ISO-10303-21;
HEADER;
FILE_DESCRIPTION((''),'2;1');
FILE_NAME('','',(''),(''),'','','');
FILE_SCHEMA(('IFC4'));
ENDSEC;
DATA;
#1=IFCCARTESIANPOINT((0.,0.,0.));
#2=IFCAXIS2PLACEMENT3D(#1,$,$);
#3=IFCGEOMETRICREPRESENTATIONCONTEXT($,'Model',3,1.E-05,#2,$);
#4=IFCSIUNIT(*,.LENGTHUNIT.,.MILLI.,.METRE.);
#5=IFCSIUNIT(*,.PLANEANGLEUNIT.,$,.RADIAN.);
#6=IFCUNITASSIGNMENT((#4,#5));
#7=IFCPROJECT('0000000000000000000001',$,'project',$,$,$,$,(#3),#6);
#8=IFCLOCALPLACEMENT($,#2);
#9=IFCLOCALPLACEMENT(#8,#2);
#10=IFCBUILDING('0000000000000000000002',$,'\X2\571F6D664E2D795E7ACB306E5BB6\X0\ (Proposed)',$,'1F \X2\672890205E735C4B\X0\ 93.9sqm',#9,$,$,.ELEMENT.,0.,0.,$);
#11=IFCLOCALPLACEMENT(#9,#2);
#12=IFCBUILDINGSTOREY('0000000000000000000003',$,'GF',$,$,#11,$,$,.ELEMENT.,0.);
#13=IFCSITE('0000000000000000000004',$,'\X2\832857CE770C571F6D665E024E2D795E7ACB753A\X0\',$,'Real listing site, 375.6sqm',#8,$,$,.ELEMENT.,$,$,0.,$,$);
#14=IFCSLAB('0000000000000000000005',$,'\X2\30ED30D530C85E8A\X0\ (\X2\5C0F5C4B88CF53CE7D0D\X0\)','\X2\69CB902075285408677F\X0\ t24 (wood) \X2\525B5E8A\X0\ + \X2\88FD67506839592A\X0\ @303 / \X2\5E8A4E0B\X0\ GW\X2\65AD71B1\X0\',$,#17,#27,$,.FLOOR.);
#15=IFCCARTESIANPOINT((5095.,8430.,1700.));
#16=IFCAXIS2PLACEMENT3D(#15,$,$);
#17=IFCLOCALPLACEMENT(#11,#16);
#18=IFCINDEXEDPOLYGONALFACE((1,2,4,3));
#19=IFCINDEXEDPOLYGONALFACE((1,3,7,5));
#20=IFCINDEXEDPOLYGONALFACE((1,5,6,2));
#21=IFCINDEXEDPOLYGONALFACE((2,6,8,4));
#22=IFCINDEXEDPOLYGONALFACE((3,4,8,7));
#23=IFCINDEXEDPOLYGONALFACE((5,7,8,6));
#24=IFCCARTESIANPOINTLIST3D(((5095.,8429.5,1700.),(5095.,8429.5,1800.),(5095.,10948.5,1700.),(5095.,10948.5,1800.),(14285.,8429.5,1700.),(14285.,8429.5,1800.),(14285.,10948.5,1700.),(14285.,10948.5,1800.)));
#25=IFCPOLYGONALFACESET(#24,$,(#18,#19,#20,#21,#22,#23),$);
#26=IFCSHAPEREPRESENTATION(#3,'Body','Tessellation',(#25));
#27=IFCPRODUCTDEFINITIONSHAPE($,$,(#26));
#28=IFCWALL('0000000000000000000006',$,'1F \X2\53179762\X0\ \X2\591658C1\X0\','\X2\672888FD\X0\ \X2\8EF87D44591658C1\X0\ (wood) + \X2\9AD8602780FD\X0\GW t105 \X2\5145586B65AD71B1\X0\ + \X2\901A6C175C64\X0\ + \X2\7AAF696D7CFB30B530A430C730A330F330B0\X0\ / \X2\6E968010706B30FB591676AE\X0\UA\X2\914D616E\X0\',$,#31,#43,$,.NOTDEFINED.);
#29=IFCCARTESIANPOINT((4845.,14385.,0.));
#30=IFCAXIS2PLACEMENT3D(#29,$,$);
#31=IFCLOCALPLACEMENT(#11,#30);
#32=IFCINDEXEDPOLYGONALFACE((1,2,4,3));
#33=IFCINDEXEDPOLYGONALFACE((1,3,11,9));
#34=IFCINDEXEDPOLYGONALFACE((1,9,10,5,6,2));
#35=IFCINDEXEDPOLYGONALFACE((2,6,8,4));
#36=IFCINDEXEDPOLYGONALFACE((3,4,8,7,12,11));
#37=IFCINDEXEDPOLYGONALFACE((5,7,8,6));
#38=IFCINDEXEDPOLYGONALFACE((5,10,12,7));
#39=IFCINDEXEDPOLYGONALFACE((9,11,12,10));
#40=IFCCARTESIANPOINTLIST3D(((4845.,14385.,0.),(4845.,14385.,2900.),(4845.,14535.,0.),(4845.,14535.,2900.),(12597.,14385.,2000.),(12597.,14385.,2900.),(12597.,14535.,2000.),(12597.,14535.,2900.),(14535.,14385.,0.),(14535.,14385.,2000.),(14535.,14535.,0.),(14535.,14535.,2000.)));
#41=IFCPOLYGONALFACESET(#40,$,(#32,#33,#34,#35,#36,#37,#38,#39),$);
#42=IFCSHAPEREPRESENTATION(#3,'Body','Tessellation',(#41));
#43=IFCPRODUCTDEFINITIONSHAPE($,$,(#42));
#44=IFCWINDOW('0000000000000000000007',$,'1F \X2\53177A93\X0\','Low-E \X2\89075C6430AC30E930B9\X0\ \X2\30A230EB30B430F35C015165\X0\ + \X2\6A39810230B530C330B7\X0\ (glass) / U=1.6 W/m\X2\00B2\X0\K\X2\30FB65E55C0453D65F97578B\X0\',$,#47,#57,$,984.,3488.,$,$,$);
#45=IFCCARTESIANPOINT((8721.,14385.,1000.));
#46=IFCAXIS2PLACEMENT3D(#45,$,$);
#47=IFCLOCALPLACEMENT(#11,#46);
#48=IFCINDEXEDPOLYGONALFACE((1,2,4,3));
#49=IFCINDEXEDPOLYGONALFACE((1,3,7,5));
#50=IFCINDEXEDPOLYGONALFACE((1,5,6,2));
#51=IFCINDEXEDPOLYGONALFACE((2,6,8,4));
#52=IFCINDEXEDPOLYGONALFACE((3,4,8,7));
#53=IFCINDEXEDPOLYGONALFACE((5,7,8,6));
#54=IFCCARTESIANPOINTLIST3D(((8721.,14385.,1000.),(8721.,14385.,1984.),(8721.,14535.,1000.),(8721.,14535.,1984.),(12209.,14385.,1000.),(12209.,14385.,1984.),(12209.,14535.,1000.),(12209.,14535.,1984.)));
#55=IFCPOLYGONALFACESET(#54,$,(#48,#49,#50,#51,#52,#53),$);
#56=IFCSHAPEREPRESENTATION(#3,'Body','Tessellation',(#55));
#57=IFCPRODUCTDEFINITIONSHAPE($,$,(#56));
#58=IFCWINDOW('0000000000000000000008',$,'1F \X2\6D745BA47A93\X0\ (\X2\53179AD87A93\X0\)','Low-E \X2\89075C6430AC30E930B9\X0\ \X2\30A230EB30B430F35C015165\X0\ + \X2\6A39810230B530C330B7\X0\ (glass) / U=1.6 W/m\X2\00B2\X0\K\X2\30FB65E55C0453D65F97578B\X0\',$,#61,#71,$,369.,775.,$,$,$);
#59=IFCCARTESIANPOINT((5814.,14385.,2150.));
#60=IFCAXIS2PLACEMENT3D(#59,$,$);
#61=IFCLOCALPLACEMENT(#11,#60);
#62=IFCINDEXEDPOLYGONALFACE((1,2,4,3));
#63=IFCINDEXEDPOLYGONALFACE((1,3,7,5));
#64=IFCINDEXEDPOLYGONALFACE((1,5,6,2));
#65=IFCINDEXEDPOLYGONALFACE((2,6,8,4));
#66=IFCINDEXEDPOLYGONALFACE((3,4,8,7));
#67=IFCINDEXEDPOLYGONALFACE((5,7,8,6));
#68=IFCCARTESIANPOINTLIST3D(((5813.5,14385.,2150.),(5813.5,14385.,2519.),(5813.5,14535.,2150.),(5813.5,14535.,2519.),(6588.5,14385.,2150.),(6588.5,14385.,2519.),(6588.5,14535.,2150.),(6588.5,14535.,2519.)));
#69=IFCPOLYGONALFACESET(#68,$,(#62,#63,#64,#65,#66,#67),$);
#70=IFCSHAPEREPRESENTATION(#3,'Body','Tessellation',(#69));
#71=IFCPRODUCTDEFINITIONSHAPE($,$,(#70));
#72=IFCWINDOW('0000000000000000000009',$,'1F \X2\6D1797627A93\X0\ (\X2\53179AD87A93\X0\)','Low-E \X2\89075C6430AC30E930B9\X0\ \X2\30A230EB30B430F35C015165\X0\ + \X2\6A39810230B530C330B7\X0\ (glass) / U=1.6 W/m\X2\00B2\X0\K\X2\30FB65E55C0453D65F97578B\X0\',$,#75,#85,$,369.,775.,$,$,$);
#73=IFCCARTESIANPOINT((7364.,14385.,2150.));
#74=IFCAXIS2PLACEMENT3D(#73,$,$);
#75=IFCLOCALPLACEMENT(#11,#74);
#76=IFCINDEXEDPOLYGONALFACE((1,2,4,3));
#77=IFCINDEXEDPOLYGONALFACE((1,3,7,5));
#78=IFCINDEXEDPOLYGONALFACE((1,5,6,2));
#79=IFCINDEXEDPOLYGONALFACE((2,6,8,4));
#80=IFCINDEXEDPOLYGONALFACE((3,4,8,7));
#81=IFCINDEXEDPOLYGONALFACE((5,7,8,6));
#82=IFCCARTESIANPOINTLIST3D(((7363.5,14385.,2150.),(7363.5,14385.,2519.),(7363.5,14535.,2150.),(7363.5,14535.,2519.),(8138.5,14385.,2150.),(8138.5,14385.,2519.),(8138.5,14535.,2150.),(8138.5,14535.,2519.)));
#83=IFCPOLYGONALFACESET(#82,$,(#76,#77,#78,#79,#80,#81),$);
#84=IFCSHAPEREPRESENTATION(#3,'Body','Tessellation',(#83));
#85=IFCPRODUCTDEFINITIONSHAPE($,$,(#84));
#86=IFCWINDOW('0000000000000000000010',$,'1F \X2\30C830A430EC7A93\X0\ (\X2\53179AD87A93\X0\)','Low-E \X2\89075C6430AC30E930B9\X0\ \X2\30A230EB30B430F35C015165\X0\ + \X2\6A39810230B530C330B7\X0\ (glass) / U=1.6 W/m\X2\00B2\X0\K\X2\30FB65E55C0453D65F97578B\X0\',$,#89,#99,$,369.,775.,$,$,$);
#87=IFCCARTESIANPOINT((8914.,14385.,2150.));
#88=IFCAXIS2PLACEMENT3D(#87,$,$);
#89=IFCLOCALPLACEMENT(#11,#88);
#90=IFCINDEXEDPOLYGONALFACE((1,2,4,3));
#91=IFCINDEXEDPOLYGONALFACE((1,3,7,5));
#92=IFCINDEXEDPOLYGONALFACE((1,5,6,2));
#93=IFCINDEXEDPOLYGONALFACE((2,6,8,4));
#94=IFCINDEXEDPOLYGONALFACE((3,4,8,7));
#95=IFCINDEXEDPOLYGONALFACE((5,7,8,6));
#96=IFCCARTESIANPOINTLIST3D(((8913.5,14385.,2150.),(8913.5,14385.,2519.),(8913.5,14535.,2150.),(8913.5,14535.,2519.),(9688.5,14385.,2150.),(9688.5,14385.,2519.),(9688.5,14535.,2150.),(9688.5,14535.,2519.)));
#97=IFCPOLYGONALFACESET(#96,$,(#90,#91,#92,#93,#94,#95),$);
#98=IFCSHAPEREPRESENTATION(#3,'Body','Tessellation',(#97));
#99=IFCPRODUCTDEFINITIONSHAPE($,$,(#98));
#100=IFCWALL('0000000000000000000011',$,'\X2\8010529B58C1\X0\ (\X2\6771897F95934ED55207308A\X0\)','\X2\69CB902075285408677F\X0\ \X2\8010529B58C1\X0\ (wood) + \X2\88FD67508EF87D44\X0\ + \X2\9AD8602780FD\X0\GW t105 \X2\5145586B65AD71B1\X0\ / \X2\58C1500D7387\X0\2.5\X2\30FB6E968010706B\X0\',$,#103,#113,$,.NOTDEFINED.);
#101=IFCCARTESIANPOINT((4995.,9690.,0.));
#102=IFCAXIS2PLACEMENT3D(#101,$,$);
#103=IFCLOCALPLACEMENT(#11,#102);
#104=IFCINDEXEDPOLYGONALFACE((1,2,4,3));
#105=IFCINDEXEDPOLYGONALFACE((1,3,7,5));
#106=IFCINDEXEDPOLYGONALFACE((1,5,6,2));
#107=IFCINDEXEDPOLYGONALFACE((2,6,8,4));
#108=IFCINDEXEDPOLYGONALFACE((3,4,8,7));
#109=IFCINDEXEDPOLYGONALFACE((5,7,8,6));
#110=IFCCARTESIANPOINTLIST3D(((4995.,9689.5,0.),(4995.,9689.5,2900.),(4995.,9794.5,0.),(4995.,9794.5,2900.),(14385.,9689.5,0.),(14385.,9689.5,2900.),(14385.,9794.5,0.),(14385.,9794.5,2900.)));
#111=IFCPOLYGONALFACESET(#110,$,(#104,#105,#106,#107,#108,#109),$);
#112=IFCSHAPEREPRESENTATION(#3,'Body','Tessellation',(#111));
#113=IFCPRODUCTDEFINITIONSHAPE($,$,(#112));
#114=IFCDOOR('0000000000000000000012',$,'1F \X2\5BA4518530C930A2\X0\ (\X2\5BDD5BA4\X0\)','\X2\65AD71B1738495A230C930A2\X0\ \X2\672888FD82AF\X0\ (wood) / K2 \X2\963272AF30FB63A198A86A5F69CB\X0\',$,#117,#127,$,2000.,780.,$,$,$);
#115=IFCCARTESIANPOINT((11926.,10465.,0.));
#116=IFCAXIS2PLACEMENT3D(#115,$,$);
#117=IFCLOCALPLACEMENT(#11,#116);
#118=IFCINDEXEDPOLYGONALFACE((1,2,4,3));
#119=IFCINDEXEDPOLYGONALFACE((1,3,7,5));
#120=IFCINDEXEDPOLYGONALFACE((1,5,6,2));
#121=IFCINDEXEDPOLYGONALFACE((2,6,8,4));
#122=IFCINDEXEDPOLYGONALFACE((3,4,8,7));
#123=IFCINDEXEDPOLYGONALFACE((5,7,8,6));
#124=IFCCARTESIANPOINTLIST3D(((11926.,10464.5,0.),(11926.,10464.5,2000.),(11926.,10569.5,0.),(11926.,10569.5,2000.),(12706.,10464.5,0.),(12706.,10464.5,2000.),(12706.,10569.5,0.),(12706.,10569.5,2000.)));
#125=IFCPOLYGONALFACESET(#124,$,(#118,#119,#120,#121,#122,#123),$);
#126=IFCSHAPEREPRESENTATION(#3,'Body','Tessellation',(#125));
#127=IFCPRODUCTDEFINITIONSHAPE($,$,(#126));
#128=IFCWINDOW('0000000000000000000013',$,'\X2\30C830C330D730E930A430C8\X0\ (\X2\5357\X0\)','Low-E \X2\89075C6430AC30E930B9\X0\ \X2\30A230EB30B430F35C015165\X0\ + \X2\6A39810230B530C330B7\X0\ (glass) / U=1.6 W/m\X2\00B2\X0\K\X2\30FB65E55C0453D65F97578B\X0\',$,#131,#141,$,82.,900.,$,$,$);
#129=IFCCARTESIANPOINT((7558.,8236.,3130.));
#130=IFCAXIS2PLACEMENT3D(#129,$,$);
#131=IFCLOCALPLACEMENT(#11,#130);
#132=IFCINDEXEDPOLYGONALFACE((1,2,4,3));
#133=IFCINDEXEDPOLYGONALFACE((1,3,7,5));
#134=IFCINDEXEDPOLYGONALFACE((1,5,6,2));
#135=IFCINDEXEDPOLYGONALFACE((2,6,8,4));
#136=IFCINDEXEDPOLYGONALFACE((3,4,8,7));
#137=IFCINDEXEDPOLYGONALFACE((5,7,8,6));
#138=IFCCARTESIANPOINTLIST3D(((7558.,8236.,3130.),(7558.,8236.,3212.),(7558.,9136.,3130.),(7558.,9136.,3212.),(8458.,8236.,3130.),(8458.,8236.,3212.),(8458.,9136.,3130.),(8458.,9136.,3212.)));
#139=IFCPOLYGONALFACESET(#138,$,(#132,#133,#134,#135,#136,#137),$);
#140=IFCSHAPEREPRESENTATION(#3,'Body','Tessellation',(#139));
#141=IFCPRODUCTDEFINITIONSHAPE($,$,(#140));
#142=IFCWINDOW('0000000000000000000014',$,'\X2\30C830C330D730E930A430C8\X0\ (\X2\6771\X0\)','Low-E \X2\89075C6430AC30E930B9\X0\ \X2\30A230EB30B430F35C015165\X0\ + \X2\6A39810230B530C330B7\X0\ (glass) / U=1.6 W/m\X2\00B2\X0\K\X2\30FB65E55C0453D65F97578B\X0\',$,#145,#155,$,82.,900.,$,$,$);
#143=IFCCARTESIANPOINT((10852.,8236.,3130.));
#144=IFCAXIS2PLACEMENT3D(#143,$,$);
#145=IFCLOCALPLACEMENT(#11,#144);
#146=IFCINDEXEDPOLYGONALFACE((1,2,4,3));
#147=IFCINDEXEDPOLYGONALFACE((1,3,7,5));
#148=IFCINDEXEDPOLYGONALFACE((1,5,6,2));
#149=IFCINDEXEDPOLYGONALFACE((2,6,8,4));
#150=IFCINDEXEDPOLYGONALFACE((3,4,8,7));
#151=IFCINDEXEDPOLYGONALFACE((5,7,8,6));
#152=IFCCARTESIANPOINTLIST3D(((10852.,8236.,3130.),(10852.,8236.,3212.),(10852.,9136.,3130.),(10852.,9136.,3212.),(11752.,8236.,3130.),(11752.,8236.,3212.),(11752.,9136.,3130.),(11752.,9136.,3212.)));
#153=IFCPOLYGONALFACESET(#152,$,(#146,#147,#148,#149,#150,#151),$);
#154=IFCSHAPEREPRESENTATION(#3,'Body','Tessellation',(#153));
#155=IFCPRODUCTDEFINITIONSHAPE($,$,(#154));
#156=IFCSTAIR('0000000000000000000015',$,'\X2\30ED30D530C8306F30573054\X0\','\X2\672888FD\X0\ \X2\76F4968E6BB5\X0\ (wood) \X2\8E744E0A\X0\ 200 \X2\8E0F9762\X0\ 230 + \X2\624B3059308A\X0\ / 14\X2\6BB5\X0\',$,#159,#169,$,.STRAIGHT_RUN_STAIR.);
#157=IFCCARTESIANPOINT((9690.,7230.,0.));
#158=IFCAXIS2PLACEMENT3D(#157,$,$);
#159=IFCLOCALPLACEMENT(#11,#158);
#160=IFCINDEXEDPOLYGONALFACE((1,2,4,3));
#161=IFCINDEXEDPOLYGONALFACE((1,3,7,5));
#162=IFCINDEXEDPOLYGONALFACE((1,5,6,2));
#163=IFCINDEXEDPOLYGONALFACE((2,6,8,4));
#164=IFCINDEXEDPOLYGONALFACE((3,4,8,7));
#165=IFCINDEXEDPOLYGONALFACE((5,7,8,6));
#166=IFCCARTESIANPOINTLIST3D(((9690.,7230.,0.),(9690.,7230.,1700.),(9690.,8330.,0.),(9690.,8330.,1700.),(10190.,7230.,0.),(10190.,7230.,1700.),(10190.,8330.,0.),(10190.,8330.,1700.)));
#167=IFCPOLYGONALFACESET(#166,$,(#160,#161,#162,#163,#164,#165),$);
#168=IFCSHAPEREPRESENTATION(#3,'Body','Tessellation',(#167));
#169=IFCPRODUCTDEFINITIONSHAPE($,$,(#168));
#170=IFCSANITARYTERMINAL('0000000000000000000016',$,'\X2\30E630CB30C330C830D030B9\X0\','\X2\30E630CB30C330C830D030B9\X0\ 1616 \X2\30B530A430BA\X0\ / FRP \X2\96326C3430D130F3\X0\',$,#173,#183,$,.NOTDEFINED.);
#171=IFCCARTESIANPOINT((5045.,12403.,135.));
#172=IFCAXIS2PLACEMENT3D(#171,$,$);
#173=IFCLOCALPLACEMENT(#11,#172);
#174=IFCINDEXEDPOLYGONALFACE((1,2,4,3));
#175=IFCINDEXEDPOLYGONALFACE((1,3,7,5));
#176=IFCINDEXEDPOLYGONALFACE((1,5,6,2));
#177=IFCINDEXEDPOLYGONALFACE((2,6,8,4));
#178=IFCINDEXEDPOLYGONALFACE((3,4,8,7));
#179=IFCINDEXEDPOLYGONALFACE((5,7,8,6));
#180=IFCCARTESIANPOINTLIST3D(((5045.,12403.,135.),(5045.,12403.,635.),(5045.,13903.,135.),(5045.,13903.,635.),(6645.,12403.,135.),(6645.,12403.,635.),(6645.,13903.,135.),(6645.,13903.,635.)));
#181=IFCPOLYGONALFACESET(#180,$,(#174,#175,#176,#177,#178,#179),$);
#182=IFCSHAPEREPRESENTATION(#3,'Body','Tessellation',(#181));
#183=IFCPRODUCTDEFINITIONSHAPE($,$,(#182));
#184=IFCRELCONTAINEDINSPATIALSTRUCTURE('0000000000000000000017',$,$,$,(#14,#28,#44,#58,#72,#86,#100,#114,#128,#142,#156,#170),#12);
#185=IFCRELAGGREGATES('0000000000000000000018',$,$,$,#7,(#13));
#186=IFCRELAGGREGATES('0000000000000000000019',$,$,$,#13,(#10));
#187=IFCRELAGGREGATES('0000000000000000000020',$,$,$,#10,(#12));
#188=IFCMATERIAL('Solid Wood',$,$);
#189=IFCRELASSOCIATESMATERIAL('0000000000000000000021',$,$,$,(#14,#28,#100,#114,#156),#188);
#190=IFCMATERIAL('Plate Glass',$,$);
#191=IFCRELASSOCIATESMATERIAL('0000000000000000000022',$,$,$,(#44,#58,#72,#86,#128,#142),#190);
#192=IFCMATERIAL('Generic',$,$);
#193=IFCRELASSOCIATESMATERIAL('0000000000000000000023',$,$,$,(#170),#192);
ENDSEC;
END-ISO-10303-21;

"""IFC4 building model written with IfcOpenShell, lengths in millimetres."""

from ifc_helpers import new_model, si_unit, frame, frame_2d, origin, place, context, project, spatial, rectangle, extrude, material, element, fill, save


model = new_model("IFC4")

# Units and contexts
model_context = context("Model", 3, precision=1e-05, world=origin())
ifc_project = project(units=[si_unit("LENGTHUNIT", "METRE", prefix="MILLI"), si_unit("PLANEANGLEUNIT", "RADIAN")], contexts=[model_context])

# Site, building, storey
site_placement = place(None, origin())
site = spatial("IfcSite", under=ifc_project, at=site_placement, Name="茨城県土浦市中神立町", ObjectType="Real listing site, 375.6sqm", CompositionType="ELEMENT", RefElevation=0.0)
building_placement = place(site_placement, origin())
building = spatial("IfcBuilding", under=site, at=building_placement, Name="土浦中神立の家 (Proposed)", ObjectType="1F 木造平屋 93.9sqm", CompositionType="ELEMENT", ElevationOfRefHeight=0.0, ElevationOfTerrain=0.0)
storey_placement = place(building_placement, origin())
storey = spatial("IfcBuildingStorey", under=building, at=storey_placement, Name="GF", CompositionType="ELEMENT", Elevation=0.0)

# Slab
ifc_material_1 = material(Name="Solid Wood")
slab_placement = place(storey_placement, frame((5095.0, 8430.0, 1700.0)))
element("IfcSlab", 1, at=slab_placement, inside=storey, material=ifc_material_1, Name="ロフト床 (小屋裏収納)", Description="構造用合板 t24 (wood) 剛床 + 製材根太 @303 / 床下 GW断熱", PredefinedType="FLOOR", context=model_context, shape_type="SweptSolid", body=[
    extrude(rectangle(XDim=9190.0, YDim=2519.0, at=frame_2d((4595.0, 1259.0))), frame((5095.0, 8430.0, 1700.0)), (0.0, 0.0, 1.0), 100.0),
])

# Wall, openings, windows
wall_1_placement = place(storey_placement, frame((4845.0, 14385.0, 0.0)))
wall_1 = element("IfcWall", 2, at=wall_1_placement, inside=storey, material=ifc_material_1, Name="1F 北面 外壁", Description="木製 軸組外壁 (wood) + 高性能GW t105 充填断熱 + 通気層 + 窯業系サイディング / 準耐火・外皮UA配慮", PredefinedType="NOTDEFINED", context=model_context, shape_type="SweptSolid", body=[
    extrude(rectangle(XDim=9690.0, YDim=150.0, at=frame_2d((4845.0, 75.0))), frame((4845.0, 14385.0, 0.0)), (0.0, 0.0, 1.0), 2900.0),
])
opening_1_placement = place(storey_placement, frame((8721.0, 14385.0, 1000.0)))
opening_1 = element("IfcOpeningElement", 3, at=opening_1_placement, cuts=wall_1, PredefinedType="NOTDEFINED", context=model_context, shape_type="SweptSolid", body=[
    extrude(rectangle(XDim=3488.0, YDim=150.0, at=frame_2d((1744.0, 75.0))), frame((8721.0, 14385.0, 1000.0)), (0.0, 0.0, 1.0), 984.0),
])
opening_2_placement = place(storey_placement, frame((5814.0, 14385.0, 2150.0)))
opening_2 = element("IfcOpeningElement", 4, at=opening_2_placement, cuts=wall_1, PredefinedType="NOTDEFINED", context=model_context, shape_type="SweptSolid", body=[
    extrude(rectangle(XDim=775.0, YDim=150.0, at=frame_2d((387.0, 75.0))), frame((5814.0, 14385.0, 2150.0)), (0.0, 0.0, 1.0), 369.0),
])
opening_3_placement = place(storey_placement, frame((7364.0, 14385.0, 2150.0)))
opening_3 = element("IfcOpeningElement", 5, at=opening_3_placement, cuts=wall_1, PredefinedType="NOTDEFINED", context=model_context, shape_type="SweptSolid", body=[
    extrude(rectangle(XDim=775.0, YDim=150.0, at=frame_2d((387.0, 75.0))), frame((7364.0, 14385.0, 2150.0)), (0.0, 0.0, 1.0), 369.0),
])
opening_4_placement = place(storey_placement, frame((8914.0, 14385.0, 2150.0)))
opening_4 = element("IfcOpeningElement", 6, at=opening_4_placement, cuts=wall_1, PredefinedType="NOTDEFINED", context=model_context, shape_type="SweptSolid", body=[
    extrude(rectangle(XDim=775.0, YDim=150.0, at=frame_2d((387.0, 75.0))), frame((8914.0, 14385.0, 2150.0)), (0.0, 0.0, 1.0), 369.0),
])
ifc_material_2 = material(Name="Plate Glass")
window_1_placement = place(storey_placement, frame((8721.0, 14385.0, 1000.0)))
window_1 = element("IfcWindow", 7, at=window_1_placement, inside=storey, material=ifc_material_2, Name="1F 北窓", Description="Low-E 複層ガラス アルゴン封入 + 樹脂サッシ (glass) / U=1.6 W/m²K・日射取得型", OverallHeight=984.0, OverallWidth=3488.0, context=model_context, shape_type="SweptSolid", body=[
    extrude(rectangle(XDim=3488.0, YDim=150.0, at=frame_2d((1744.0, 75.0))), frame((8721.0, 14385.0, 1000.0)), (0.0, 0.0, 1.0), 984.0),
])
fill(opening_1, window_1)
window_2_placement = place(storey_placement, frame((5814.0, 14385.0, 2150.0)))
window_2 = element("IfcWindow", 8, at=window_2_placement, inside=storey, material=ifc_material_2, Name="1F 浴室窓 (北高窓)", Description="Low-E 複層ガラス アルゴン封入 + 樹脂サッシ (glass) / U=1.6 W/m²K・日射取得型", OverallHeight=369.0, OverallWidth=775.0, context=model_context, shape_type="SweptSolid", body=[
    extrude(rectangle(XDim=775.0, YDim=150.0, at=frame_2d((387.0, 75.0))), frame((5814.0, 14385.0, 2150.0)), (0.0, 0.0, 1.0), 369.0),
])
fill(opening_2, window_2)
window_3_placement = place(storey_placement, frame((7364.0, 14385.0, 2150.0)))
window_3 = element("IfcWindow", 9, at=window_3_placement, inside=storey, material=ifc_material_2, Name="1F 洗面窓 (北高窓)", Description="Low-E 複層ガラス アルゴン封入 + 樹脂サッシ (glass) / U=1.6 W/m²K・日射取得型", OverallHeight=369.0, OverallWidth=775.0, context=model_context, shape_type="SweptSolid", body=[
    extrude(rectangle(XDim=775.0, YDim=150.0, at=frame_2d((387.0, 75.0))), frame((7364.0, 14385.0, 2150.0)), (0.0, 0.0, 1.0), 369.0),
])
fill(opening_3, window_3)
window_4_placement = place(storey_placement, frame((8914.0, 14385.0, 2150.0)))
window_4 = element("IfcWindow", 10, at=window_4_placement, inside=storey, material=ifc_material_2, Name="1F トイレ窓 (北高窓)", Description="Low-E 複層ガラス アルゴン封入 + 樹脂サッシ (glass) / U=1.6 W/m²K・日射取得型", OverallHeight=369.0, OverallWidth=775.0, context=model_context, shape_type="SweptSolid", body=[
    extrude(rectangle(XDim=775.0, YDim=150.0, at=frame_2d((387.0, 75.0))), frame((8914.0, 14385.0, 2150.0)), (0.0, 0.0, 1.0), 369.0),
])
fill(opening_4, window_4)

# Wall
wall_2_placement = place(storey_placement, frame((4995.0, 9690.0, 0.0)))
element("IfcWall", 11, at=wall_2_placement, inside=storey, material=ifc_material_1, Name="耐力壁 (東西間仕切り)", Description="構造用合板 耐力壁 (wood) + 製材軸組 + 高性能GW t105 充填断熱 / 壁倍率2.5・準耐火", PredefinedType="NOTDEFINED", context=model_context, shape_type="SweptSolid", body=[
    extrude(rectangle(XDim=9390.0, YDim=105.0, at=frame_2d((4695.0, 52.0))), frame((4995.0, 9690.0, 0.0)), (0.0, 0.0, 1.0), 2900.0),
])

# Door
door_1_placement = place(storey_placement, frame((11926.0, 10465.0, 0.0)))
element("IfcDoor", 12, at=door_1_placement, inside=storey, material=ifc_material_1, Name="1F 室内ドア (寝室)", Description="断熱玄関ドア 木製芯 (wood) / K2 防犯・採風機構", OverallHeight=2000.0, OverallWidth=780.0, context=model_context, shape_type="SweptSolid", body=[
    extrude(rectangle(XDim=780.0, YDim=105.0, at=frame_2d((390.0, 52.0))), frame((11926.0, 10465.0, 0.0)), (0.0, 0.0, 1.0), 2000.0),
])

# Windows
window_5_placement = place(storey_placement, frame((7558.0, 8236.0, 3130.0)))
element("IfcWindow", 13, at=window_5_placement, inside=storey, material=ifc_material_2, Name="トップライト (南)", Description="Low-E 複層ガラス アルゴン封入 + 樹脂サッシ (glass) / U=1.6 W/m²K・日射取得型", OverallHeight=82.0, OverallWidth=900.0, context=model_context, shape_type="SweptSolid", body=[
    extrude(rectangle(XDim=900.0, YDim=900.0, at=frame_2d((450.0, 450.0))), frame((7558.0, 8236.0, 3130.0)), (0.0, 0.0, 1.0), 82.0),
])
window_6_placement = place(storey_placement, frame((10852.0, 8236.0, 3130.0)))
element("IfcWindow", 14, at=window_6_placement, inside=storey, material=ifc_material_2, Name="トップライト (東)", Description="Low-E 複層ガラス アルゴン封入 + 樹脂サッシ (glass) / U=1.6 W/m²K・日射取得型", OverallHeight=82.0, OverallWidth=900.0, context=model_context, shape_type="SweptSolid", body=[
    extrude(rectangle(XDim=900.0, YDim=900.0, at=frame_2d((450.0, 450.0))), frame((10852.0, 8236.0, 3130.0)), (0.0, 0.0, 1.0), 82.0),
])

# Stair
stair_placement = place(storey_placement, frame((9690.0, 7230.0, 0.0)))
element("IfcStair", 15, at=stair_placement, inside=storey, material=ifc_material_1, Name="ロフトはしご", Description="木製 直階段 (wood) 蹴上 200 踏面 230 + 手すり / 14段", PredefinedType="STRAIGHT_RUN_STAIR", context=model_context, shape_type="SweptSolid", body=[
    extrude(rectangle(XDim=500.0, YDim=1100.0, at=frame_2d((250.0, 550.0))), frame((9690.0, 7230.0, 0.0)), (0.0, 0.0, 1.0), 1700.0),
])

# Sanitary terminal
ifc_material_3 = material(Name="Generic")
sanitary_terminal_1_placement = place(storey_placement, frame((5045.0, 12403.0, 135.0)))
element("IfcSanitaryTerminal", 16, at=sanitary_terminal_1_placement, inside=storey, material=ifc_material_3, Name="ユニットバス", Description="ユニットバス 1616 サイズ / FRP 防水パン", PredefinedType="NOTDEFINED", context=model_context, shape_type="SweptSolid", body=[
    extrude(rectangle(XDim=1600.0, YDim=1500.0, at=frame_2d((800.0, 750.0))), frame((5045.0, 12403.0, 135.0)), (0.0, 0.0, 1.0), 500.0),
])

save(model, "model.ifc")
